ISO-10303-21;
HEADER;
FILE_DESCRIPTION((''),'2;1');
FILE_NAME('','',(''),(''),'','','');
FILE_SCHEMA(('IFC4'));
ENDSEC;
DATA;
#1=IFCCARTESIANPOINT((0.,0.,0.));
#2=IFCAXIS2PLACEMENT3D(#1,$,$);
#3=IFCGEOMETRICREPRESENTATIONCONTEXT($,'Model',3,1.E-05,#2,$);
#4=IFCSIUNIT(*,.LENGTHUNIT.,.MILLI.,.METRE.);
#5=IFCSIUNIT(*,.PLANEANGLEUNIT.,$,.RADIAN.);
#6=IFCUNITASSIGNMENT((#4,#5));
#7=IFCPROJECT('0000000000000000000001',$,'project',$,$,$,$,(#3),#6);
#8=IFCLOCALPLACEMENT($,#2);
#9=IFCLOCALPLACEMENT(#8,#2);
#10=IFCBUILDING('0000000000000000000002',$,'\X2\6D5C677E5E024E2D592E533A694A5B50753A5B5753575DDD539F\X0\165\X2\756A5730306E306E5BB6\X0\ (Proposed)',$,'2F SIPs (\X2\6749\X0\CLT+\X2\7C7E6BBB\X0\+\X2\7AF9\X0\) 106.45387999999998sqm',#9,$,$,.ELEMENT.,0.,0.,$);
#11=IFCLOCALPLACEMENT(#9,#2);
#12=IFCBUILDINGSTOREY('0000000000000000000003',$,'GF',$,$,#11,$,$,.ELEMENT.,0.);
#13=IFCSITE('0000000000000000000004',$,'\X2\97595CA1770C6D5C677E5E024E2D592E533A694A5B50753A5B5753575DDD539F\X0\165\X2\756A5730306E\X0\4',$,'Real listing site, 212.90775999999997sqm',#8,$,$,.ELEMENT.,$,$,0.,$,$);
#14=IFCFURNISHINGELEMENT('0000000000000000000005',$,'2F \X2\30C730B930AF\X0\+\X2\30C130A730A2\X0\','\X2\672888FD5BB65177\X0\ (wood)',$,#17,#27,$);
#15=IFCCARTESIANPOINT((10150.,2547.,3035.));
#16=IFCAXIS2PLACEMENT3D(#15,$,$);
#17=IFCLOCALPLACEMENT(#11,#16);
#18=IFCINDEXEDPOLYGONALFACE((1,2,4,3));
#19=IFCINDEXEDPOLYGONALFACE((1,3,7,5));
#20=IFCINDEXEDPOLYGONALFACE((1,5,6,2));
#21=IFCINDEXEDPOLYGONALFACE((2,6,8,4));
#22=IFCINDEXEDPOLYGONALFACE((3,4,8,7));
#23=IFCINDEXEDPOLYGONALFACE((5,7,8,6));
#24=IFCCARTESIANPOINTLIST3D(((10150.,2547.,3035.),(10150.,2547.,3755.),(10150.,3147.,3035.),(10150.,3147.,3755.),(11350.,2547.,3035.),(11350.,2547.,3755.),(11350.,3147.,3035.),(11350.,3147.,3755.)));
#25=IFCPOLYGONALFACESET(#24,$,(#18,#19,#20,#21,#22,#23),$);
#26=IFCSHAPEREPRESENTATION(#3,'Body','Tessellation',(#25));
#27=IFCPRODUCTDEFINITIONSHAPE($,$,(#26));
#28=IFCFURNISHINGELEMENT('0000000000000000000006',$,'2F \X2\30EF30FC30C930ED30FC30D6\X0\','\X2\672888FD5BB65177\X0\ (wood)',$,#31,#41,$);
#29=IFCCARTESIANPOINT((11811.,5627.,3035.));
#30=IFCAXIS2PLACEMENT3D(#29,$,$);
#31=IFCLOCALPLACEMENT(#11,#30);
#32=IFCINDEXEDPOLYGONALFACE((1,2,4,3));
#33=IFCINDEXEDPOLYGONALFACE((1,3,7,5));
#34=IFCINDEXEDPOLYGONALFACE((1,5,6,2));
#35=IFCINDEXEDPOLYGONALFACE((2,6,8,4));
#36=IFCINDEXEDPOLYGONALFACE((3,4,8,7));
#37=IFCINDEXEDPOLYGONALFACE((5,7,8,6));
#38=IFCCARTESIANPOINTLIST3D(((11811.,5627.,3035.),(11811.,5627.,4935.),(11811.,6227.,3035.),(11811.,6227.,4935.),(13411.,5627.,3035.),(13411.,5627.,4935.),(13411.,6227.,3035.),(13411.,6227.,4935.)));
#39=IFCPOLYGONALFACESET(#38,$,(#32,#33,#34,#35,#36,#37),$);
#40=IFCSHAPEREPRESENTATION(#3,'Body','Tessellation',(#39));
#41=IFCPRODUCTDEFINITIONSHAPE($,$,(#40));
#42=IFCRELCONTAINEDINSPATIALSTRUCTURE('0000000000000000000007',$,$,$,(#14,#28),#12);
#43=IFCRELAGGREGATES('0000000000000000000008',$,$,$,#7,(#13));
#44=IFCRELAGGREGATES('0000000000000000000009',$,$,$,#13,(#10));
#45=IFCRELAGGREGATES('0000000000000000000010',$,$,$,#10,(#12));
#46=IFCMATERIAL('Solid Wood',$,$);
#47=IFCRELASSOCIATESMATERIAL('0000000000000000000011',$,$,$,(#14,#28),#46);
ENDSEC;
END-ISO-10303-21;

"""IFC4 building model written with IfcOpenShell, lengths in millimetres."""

from ifc_helpers import new_model, si_unit, frame, frame_2d, origin, place, context, project, spatial, rectangle, extrude, material, element, save


model = new_model("IFC4")

# Units and contexts
model_context = context("Model", 3, precision=1e-05, world=origin())
ifc_project = project(units=[si_unit("LENGTHUNIT", "METRE", prefix="MILLI"), si_unit("PLANEANGLEUNIT", "RADIAN")], contexts=[model_context])

# Site, building, storey
site_placement = place(None, origin())
site = spatial("IfcSite", under=ifc_project, at=site_placement, Name="静岡県浜松市中央区楊子町字南川原165番地の4", ObjectType="Real listing site, 212.90775999999997sqm", CompositionType="ELEMENT", RefElevation=0.0)
building_placement = place(site_placement, origin())
building = spatial("IfcBuilding", under=site, at=building_placement, Name="浜松市中央区楊子町字南川原165番地のの家 (Proposed)", ObjectType="2F SIPs (杉CLT+籾殻+竹) 106.45387999999998sqm", CompositionType="ELEMENT", ElevationOfRefHeight=0.0, ElevationOfTerrain=0.0)
storey_placement = place(building_placement, origin())
storey = spatial("IfcBuildingStorey", under=building, at=storey_placement, Name="GF", CompositionType="ELEMENT", Elevation=0.0)

# Shared definitions
ifc_material_1 = material(Name="Solid Wood")

# Furnishing elements
furnishing_1_placement = place(storey_placement, frame((10150.0, 2547.0, 3035.0)))
element("IfcFurnishingElement", 1, at=furnishing_1_placement, inside=storey, material=ifc_material_1, Name="2F デスク+チェア", Description="木製家具 (wood)", context=model_context, shape_type="SweptSolid", body=[
    extrude(rectangle(XDim=1200.0, YDim=600.0, at=frame_2d((600.0, 300.0))), frame((10150.0, 2547.0, 3035.0)), (0.0, 0.0, 1.0), 720.0),
])
furnishing_2_placement = place(storey_placement, frame((11811.0, 5627.0, 3035.0)))
element("IfcFurnishingElement", 2, at=furnishing_2_placement, inside=storey, material=ifc_material_1, Name="2F ワードローブ", Description="木製家具 (wood)", context=model_context, shape_type="SweptSolid", body=[
    extrude(rectangle(XDim=1600.0, YDim=600.0, at=frame_2d((800.0, 300.0))), frame((11811.0, 5627.0, 3035.0)), (0.0, 0.0, 1.0), 1900.0),
])

save(model, "model.ifc")
